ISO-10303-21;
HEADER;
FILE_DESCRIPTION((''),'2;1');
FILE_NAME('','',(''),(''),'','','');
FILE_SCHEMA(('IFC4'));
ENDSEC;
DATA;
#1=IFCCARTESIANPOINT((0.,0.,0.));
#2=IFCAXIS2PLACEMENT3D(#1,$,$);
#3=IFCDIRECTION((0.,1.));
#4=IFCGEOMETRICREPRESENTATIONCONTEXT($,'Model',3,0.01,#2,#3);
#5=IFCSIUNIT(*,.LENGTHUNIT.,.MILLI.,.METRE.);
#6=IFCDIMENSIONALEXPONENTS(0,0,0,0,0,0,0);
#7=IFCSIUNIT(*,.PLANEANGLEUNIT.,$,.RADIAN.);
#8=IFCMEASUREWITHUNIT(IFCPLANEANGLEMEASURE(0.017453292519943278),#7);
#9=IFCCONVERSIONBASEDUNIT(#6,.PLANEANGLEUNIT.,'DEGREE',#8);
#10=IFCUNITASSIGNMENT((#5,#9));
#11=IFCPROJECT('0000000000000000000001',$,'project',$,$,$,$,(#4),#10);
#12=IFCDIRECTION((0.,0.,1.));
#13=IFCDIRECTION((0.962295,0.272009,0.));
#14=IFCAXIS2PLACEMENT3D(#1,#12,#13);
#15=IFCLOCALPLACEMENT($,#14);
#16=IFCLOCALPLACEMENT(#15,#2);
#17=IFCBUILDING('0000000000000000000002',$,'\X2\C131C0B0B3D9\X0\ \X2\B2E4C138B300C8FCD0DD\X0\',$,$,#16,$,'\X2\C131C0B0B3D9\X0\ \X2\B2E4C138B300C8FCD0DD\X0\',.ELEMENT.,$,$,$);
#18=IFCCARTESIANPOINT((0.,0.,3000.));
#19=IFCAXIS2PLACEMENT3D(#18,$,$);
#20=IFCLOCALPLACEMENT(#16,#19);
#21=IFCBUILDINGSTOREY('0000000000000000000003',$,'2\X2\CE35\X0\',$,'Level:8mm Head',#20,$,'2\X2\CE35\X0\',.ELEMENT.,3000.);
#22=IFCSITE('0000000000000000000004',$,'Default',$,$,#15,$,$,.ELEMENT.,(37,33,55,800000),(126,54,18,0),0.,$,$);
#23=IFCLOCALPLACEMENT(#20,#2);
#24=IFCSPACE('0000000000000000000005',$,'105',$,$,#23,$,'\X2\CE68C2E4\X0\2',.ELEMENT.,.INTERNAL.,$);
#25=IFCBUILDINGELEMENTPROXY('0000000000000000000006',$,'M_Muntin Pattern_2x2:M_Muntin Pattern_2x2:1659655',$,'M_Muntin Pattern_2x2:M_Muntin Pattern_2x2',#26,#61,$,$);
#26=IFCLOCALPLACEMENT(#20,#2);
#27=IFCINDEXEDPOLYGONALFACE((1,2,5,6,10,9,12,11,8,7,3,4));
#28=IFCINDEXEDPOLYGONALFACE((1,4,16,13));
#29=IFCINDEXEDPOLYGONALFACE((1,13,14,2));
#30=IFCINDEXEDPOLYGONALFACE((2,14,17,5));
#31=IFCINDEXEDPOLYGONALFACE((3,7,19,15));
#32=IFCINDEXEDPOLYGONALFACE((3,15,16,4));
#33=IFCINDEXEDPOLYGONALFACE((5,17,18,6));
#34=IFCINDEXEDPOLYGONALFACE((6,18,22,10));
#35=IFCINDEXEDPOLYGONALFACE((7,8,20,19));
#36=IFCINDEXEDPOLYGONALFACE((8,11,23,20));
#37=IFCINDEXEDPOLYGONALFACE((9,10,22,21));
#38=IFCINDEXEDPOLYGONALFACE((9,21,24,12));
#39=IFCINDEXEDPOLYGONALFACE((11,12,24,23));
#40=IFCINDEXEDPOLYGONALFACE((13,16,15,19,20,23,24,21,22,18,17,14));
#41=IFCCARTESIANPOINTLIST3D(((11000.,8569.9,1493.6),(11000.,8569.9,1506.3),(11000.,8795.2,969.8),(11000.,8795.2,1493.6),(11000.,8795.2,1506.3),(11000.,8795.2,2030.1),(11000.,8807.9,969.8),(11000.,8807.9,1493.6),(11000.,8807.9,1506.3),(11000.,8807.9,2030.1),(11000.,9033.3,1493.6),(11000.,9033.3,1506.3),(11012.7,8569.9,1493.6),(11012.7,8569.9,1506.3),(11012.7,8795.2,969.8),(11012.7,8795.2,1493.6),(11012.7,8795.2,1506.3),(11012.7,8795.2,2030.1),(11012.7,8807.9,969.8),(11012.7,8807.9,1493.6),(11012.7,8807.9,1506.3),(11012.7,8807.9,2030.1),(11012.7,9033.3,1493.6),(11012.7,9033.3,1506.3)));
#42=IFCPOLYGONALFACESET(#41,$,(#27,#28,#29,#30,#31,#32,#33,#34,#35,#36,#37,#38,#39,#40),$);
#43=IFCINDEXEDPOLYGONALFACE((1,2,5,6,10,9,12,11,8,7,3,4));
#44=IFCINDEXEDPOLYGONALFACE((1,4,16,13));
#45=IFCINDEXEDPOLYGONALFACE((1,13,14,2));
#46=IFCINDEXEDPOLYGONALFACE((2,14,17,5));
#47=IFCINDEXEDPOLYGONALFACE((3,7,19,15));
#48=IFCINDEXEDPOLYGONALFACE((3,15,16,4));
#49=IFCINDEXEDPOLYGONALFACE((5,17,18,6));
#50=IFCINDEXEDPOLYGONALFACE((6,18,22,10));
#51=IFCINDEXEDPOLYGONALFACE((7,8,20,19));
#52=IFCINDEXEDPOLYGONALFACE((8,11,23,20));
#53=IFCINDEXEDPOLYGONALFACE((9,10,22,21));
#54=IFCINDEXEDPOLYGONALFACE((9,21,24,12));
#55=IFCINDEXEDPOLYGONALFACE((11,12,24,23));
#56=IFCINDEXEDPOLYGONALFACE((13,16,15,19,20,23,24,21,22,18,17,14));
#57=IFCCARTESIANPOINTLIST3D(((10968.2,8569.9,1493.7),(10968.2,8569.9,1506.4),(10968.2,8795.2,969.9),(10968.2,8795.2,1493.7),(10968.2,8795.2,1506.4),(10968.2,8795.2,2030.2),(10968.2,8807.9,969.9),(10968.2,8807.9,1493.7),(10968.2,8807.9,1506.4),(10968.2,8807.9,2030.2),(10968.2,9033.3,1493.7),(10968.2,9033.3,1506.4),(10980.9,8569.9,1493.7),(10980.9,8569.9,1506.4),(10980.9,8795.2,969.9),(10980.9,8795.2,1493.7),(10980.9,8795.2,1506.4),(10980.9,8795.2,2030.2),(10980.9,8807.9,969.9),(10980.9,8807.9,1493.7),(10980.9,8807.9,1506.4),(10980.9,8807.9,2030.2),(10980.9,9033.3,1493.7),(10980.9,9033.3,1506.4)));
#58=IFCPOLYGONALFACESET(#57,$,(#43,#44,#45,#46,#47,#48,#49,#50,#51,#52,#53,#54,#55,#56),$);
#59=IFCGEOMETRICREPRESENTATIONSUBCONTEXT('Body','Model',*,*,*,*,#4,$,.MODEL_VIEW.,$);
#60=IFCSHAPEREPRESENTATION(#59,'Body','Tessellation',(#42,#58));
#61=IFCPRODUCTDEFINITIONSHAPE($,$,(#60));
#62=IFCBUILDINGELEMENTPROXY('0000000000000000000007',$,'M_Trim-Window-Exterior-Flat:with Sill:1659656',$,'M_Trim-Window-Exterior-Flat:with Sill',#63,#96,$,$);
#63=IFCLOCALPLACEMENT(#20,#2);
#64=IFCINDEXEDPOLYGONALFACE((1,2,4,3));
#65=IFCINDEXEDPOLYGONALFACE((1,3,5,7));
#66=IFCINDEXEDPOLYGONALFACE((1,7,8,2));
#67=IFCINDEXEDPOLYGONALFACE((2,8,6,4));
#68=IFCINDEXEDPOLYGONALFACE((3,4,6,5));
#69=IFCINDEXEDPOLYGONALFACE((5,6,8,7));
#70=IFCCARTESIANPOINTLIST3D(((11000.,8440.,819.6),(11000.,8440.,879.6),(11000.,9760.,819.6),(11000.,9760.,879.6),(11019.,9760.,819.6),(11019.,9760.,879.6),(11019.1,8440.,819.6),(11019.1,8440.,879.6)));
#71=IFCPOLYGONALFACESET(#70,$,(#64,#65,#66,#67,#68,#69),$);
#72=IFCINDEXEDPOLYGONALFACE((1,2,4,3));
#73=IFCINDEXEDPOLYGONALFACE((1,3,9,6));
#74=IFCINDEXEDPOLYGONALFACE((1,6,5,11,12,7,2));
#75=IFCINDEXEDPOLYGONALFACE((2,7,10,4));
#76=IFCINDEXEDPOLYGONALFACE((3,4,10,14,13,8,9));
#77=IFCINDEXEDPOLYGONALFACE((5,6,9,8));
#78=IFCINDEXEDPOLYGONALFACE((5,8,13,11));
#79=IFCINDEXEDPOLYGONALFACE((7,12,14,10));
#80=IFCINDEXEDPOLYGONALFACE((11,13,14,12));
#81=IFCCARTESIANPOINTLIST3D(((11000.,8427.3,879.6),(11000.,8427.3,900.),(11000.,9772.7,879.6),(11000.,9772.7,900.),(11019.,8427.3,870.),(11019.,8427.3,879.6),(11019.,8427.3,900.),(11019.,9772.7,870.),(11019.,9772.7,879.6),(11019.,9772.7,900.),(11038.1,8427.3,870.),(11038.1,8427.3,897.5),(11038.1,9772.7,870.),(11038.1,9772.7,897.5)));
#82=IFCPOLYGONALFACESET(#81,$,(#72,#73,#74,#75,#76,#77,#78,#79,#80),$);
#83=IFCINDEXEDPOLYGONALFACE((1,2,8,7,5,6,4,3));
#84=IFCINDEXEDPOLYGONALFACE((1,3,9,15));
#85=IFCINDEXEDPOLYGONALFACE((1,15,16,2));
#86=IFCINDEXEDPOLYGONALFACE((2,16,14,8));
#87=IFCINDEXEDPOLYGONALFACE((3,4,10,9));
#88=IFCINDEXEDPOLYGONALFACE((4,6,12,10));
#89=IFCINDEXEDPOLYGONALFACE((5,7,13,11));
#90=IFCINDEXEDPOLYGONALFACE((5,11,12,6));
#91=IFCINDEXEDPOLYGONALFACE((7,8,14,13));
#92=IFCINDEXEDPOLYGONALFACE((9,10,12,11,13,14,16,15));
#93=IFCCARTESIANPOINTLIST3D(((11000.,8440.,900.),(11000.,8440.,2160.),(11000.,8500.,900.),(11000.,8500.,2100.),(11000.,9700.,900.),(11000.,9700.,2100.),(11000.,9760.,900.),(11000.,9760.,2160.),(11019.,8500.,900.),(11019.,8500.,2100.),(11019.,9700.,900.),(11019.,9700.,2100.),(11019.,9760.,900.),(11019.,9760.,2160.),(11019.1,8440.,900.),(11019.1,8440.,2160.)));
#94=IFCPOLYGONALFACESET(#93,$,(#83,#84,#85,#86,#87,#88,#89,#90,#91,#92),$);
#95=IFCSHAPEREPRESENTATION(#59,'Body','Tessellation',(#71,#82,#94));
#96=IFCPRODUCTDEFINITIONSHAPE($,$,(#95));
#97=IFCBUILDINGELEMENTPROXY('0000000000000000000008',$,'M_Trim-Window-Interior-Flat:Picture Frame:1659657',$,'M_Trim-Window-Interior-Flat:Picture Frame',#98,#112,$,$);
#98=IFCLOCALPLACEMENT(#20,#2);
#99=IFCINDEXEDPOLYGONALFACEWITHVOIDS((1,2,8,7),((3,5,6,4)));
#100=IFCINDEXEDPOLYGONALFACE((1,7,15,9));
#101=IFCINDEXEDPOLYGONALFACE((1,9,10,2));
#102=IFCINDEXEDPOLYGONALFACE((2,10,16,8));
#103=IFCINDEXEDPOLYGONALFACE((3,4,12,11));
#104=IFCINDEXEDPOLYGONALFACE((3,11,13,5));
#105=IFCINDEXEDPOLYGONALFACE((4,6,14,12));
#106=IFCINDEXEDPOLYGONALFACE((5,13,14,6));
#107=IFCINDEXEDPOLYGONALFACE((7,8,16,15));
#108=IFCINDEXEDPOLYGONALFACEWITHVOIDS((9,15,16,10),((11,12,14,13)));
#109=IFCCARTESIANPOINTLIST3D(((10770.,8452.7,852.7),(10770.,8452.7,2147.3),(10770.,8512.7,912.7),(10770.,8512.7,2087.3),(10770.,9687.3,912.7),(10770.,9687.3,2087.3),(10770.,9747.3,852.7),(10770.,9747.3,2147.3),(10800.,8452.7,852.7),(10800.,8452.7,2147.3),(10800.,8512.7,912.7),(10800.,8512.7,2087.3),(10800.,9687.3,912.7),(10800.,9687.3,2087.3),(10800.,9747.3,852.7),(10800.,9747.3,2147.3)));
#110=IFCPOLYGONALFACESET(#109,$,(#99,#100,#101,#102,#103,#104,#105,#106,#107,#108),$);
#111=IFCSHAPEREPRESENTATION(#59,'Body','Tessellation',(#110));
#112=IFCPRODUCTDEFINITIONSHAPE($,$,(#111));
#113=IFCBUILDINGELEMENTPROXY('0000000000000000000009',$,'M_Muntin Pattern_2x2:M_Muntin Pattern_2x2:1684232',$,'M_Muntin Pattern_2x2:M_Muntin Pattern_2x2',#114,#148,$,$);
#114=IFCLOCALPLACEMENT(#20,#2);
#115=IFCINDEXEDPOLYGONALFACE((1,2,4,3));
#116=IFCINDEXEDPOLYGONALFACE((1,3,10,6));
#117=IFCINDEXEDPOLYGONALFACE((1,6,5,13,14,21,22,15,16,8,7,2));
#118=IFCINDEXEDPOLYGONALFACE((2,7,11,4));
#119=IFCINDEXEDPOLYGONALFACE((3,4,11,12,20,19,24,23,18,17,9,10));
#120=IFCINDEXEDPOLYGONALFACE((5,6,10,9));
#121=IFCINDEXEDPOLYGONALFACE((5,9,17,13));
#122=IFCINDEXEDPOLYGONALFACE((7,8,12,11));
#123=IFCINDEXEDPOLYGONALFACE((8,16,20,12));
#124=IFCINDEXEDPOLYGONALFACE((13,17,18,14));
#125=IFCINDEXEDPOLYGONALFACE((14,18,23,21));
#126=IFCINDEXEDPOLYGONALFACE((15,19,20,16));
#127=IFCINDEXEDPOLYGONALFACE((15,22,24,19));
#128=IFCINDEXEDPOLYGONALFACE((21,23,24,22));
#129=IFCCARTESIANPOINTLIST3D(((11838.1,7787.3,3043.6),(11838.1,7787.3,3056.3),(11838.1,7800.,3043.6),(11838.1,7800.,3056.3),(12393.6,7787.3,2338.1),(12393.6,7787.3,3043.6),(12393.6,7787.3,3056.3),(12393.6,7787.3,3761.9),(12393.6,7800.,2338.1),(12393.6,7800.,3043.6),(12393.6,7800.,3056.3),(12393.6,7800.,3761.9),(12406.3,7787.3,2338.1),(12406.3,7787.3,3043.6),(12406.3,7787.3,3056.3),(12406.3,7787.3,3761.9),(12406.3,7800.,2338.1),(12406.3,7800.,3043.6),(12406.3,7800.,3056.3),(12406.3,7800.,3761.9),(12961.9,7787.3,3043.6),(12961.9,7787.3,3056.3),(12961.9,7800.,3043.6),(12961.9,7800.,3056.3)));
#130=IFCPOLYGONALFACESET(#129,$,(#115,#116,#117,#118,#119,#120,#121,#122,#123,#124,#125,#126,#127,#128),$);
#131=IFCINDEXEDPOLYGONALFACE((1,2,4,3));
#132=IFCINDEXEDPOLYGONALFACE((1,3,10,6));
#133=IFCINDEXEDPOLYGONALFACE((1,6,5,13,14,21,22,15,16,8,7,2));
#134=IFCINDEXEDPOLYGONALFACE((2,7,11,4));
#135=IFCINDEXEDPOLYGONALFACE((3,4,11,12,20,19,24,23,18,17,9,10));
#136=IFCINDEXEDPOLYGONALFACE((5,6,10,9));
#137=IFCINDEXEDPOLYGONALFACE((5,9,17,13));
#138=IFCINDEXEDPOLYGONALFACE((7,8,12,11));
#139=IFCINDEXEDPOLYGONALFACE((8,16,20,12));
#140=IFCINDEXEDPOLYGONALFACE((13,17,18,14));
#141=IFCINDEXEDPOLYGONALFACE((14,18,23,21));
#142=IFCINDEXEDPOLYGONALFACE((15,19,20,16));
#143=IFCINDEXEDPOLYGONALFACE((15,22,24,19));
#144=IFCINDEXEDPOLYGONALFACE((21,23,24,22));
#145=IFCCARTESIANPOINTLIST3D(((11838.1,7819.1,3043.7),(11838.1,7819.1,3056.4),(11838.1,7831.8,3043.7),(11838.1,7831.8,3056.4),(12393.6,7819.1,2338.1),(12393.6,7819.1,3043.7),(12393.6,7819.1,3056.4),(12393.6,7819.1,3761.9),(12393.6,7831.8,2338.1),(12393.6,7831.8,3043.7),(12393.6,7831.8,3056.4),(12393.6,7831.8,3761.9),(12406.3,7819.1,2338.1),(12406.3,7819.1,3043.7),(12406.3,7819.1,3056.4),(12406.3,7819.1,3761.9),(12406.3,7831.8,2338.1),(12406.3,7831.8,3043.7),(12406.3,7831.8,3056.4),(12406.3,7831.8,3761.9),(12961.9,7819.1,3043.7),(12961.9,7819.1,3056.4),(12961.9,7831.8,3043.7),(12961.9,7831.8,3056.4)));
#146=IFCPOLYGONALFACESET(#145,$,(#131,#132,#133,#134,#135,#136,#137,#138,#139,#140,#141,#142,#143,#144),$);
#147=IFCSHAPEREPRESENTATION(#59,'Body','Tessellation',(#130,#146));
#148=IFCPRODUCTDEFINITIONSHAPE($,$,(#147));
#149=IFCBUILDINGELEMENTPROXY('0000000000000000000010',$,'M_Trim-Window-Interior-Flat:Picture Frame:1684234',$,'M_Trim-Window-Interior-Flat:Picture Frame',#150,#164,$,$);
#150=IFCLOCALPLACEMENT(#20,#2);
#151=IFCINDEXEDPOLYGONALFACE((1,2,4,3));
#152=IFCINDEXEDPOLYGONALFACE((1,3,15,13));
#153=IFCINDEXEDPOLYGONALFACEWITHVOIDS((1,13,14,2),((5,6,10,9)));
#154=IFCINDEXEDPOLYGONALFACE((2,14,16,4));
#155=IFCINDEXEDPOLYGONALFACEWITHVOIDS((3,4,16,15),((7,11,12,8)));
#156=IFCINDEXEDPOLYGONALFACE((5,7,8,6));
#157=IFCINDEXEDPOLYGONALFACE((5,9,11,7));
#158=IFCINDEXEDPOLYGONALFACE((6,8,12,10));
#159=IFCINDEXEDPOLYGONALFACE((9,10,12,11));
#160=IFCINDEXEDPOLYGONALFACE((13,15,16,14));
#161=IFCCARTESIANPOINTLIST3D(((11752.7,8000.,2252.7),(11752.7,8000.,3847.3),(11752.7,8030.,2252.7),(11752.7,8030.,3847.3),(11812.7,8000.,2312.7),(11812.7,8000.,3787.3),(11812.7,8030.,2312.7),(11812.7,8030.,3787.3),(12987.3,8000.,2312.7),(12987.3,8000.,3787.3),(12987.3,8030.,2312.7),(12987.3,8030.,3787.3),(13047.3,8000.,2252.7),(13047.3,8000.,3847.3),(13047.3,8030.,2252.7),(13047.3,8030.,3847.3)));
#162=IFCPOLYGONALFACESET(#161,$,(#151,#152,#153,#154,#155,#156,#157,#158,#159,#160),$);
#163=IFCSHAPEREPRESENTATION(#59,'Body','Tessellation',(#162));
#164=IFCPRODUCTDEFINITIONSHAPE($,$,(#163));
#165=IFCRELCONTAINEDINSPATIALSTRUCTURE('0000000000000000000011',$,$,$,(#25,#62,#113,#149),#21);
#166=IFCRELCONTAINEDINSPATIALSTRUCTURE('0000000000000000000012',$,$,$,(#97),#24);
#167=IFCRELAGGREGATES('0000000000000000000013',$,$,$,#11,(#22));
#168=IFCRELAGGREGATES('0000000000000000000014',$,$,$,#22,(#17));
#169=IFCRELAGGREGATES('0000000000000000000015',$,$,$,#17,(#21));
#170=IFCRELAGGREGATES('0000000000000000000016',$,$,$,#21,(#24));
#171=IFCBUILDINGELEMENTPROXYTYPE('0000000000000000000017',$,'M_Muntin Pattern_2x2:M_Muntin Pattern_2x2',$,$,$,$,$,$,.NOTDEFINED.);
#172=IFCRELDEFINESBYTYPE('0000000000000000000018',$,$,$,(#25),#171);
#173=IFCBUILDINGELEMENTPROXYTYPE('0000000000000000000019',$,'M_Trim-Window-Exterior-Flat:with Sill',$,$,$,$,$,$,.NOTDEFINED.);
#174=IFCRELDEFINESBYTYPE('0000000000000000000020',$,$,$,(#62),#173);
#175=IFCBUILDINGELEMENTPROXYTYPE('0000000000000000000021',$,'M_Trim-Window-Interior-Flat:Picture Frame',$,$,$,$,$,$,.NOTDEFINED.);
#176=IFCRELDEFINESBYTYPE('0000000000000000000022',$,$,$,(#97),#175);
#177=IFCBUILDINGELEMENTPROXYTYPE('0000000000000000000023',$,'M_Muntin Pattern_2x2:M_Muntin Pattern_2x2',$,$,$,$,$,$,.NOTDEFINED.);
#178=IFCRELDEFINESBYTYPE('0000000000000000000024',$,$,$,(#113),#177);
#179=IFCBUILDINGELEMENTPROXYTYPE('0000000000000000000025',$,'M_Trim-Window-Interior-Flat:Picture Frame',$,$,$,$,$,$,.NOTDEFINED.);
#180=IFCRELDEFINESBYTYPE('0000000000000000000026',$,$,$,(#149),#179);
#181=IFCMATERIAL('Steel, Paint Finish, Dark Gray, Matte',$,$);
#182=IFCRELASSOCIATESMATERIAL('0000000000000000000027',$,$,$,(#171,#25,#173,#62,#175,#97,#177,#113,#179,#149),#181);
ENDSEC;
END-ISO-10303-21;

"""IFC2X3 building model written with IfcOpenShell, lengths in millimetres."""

from ifc_helpers import new_model, entity, si_unit, converted_unit, direction, frame, frame_2d, origin, place, context, subcontext, project, spatial, polyline, rectangle, outline, extrude, source, transform, mapped, material, type_object, type_shapes, element, save


model = new_model("IFC2X3")

# Units and contexts
model_context = context("Model", 3, precision=0.01, world=origin(), true_north=direction((0.0, 1.0)))
body_context = subcontext(model_context, "Body", "Model", "MODEL_VIEW")
ifc_project = project(units=[si_unit("LENGTHUNIT", "METRE", prefix="MILLI"), converted_unit("PLANEANGLEUNIT", "DEGREE", entity("IfcPlaneAngleMeasure", 0.017453292519943278), si_unit("PLANEANGLEUNIT", "RADIAN"), dimensions=[0, 0, 0, 0, 0, 0, 0])], contexts=[model_context])

# Site, building, storey
site_placement = place(None, frame((0.0, 0.0, 0.0), z_axis=(0.0, 0.0, 1.0), x_axis=(0.962295, 0.272009, 0.0)))
site = spatial("IfcSite", under=ifc_project, at=site_placement, Name="Default", CompositionType="ELEMENT", RefLatitude=(37, 33, 55, 800000), RefLongitude=(126, 54, 18, 0), RefElevation=0.0)
building_placement = place(site_placement, origin())
building = spatial("IfcBuilding", under=site, at=building_placement, Name="성산동 다세대주택", LongName="성산동 다세대주택", CompositionType="ELEMENT")
storey_placement = place(building_placement, frame((0.0, 0.0, 3000.0)))
storey = spatial("IfcBuildingStorey", under=building, at=storey_placement, Name="2층", ObjectType="Level:8mm Head", LongName="2층", CompositionType="ELEMENT", Elevation=3000.0)

# Shared definitions
ifc_material_1 = material(Name="Steel, Paint Finish, Dark Gray, Matte")

# Building element proxies
building_element_proxy_type_1 = type_object("IfcBuildingElementProxyType", Name="M_Muntin Pattern_2x2:M_Muntin Pattern_2x2", PredefinedType="NOTDEFINED", material=ifc_material_1)
shared_shape_1 = source(origin(), body_context, "Body", "SweptSolid", [
    extrude(outline(polyline([(6.4, -6.4), (530.1, -6.4), (530.1, 6.3), (6.4, 6.3), (6.4, 231.7), (-6.3, 231.7), (-6.3, 6.3), (-530.2, 6.3), (-530.2, -6.4), (-6.3, -6.4), (-6.3, -231.7), (6.4, -231.7), (6.4, -6.4)])), frame((0.0, -22.2, 530.1), z_axis=(0.0, 1.0, 0.0), x_axis=(0.0, 0.0, 1.0)), (0.0, 0.0, 1.0), 12.7),
    extrude(outline(polyline([(6.4, -6.4), (530.2, -6.4), (530.2, 6.3), (6.4, 6.3), (6.4, 231.7), (-6.3, 231.7), (-6.3, 6.3), (-530.2, 6.3), (-530.2, -6.4), (-6.3, -6.4), (-6.3, -231.7), (6.4, -231.7), (6.4, -6.4)])), frame((0.0, 9.5, 530.2), z_axis=(0.0, 1.0, 0.0), x_axis=(0.0, 0.0, 1.0)), (0.0, 0.0, 1.0), 12.7),
])
type_shapes(building_element_proxy_type_1, [shared_shape_1])
proxy_1_placement = place(storey_placement, frame((10990.5, 8801.6, 969.9), z_axis=(0.0, 0.0, 1.0), x_axis=(0.0, 1.0, 0.0)))
element("IfcBuildingElementProxy", 1, at=proxy_1_placement, inside=storey, type_object=building_element_proxy_type_1, material=ifc_material_1, Name="M_Muntin Pattern_2x2:M_Muntin Pattern_2x2:1659655", ObjectType="M_Muntin Pattern_2x2:M_Muntin Pattern_2x2", context=body_context, shape_type="MappedRepresentation", body=[
    mapped(shared_shape_1, transform((0.0, 0.0, 0.0), scale=1.0)),
])
building_element_proxy_type_2 = type_object("IfcBuildingElementProxyType", Name="M_Trim-Window-Exterior-Flat:with Sill", PredefinedType="NOTDEFINED", material=ifc_material_1)
shared_shape_2 = source(origin(), body_context, "Body", "SweptSolid", [
    extrude(rectangle(XDim=1320.0, YDim=60.0, at=frame_2d((0.0, 0.0), x_axis=(1.0, 0.0))), frame((0.0, -1250.4, 0.0), z_axis=(0.0, 0.0, 1.0), x_axis=(-1.0, 0.0, 0.0)), (0.0, 0.0, 1.0), 19.0),
    extrude(outline(polyline([(-19.0, -15.2), (0.0, -15.2), (0.0, -5.7), (19.0, -5.7), (19.0, 14.8), (0.0, 14.8), (-19.0, 12.3), (-19.0, -15.2)])), frame((-672.7, -1214.8, 19.0), z_axis=(1.0, 0.0, 0.0), x_axis=(0.0, 0.0, -1.0)), (0.0, 0.0, 1.0), 1345.4),
    extrude(outline(polyline([(-645.0, -660.0), (615.0, -660.0), (615.0, -600.0), (-585.0, -600.0), (-585.0, 600.0), (615.0, 600.0), (615.0, 660.0), (-645.0, 660.0), (-645.0, -660.0)])), frame((0.0, -585.0, 0.0), z_axis=(0.0, 0.0, 1.0), x_axis=(0.0, -1.0, 0.0)), (0.0, 0.0, 1.0), 19.0),
])
type_shapes(building_element_proxy_type_2, [shared_shape_2])
proxy_2_placement = place(storey_placement, frame((11000.0, 9100.0, 2100.0), z_axis=(1.0, 0.0, 0.0), x_axis=(0.0, 1.0, 0.0)))
element("IfcBuildingElementProxy", 2, at=proxy_2_placement, inside=storey, type_object=building_element_proxy_type_2, material=ifc_material_1, Name="M_Trim-Window-Exterior-Flat:with Sill:1659656", ObjectType="M_Trim-Window-Exterior-Flat:with Sill", context=body_context, shape_type="MappedRepresentation", body=[
    mapped(shared_shape_2, transform((0.0, 0.0, 0.0), scale=1.0)),
])

# Shared definitions
space_1_placement = place(storey_placement, origin())
space_1 = spatial("IfcSpace", under=storey, at=space_1_placement, Name="105", LongName="침실2", CompositionType="ELEMENT", InteriorOrExteriorSpace="INTERNAL")

# Building element proxies
building_element_proxy_type_3 = type_object("IfcBuildingElementProxyType", Name="M_Trim-Window-Interior-Flat:Picture Frame", PredefinedType="NOTDEFINED", material=ifc_material_1)
shared_shape_3 = source(origin(), body_context, "Body", "SweptSolid", [
    extrude(outline(polyline([(-647.3, -647.3), (647.3, -647.3), (647.3, 647.3), (-647.3, 647.3), (-647.3, -647.3)]), holes=[polyline([(-587.3, -587.3), (-587.3, 587.3), (587.3, 587.3), (587.3, -587.3), (-587.3, -587.3)])]), frame((0.0, -600.0, 0.0), z_axis=(0.0, 0.0, 1.0), x_axis=(-1.0, 0.0, 0.0)), (0.0, 0.0, 1.0), 30.0),
])
type_shapes(building_element_proxy_type_3, [shared_shape_3])
proxy_3_placement = place(space_1_placement, frame((10800.0, 9100.0, 2100.0), z_axis=(-1.0, 0.0, 0.0), x_axis=(0.0, -1.0, 0.0)))
element("IfcBuildingElementProxy", 3, at=proxy_3_placement, inside=space_1, type_object=building_element_proxy_type_3, material=ifc_material_1, Name="M_Trim-Window-Interior-Flat:Picture Frame:1659657", ObjectType="M_Trim-Window-Interior-Flat:Picture Frame", context=body_context, shape_type="MappedRepresentation", body=[
    mapped(shared_shape_3, transform((0.0, 0.0, 0.0), scale=1.0)),
])
building_element_proxy_type_4 = type_object("IfcBuildingElementProxyType", Name="M_Muntin Pattern_2x2:M_Muntin Pattern_2x2", PredefinedType="NOTDEFINED", material=ifc_material_1)
shared_shape_4 = source(origin(), body_context, "Body", "SweptSolid", [
    extrude(outline(polyline([(6.4, -6.4), (711.9, -6.4), (711.9, 6.3), (6.4, 6.3), (6.4, 561.9), (-6.3, 561.9), (-6.3, 6.3), (-711.9, 6.3), (-711.9, -6.4), (-6.3, -6.4), (-6.3, -561.9), (6.4, -561.9), (6.4, -6.4)])), frame((0.0, -22.2, 711.9), z_axis=(0.0, 1.0, 0.0), x_axis=(0.0, 0.0, 1.0)), (0.0, 0.0, 1.0), 12.7),
    extrude(outline(polyline([(6.4, -6.4), (711.9, -6.4), (711.9, 6.3), (6.4, 6.3), (6.4, 561.9), (-6.3, 561.9), (-6.3, 6.3), (-711.9, 6.3), (-711.9, -6.4), (-6.3, -6.4), (-6.3, -561.9), (6.4, -561.9), (6.4, -6.4)])), frame((0.0, 9.5, 711.9), z_axis=(0.0, 1.0, 0.0), x_axis=(0.0, 0.0, 1.0)), (0.0, 0.0, 1.0), 12.7),
])
type_shapes(building_element_proxy_type_4, [shared_shape_4])
proxy_4_placement = place(storey_placement, frame((12400.0, 7809.5, 2338.1)))
element("IfcBuildingElementProxy", 4, at=proxy_4_placement, inside=storey, type_object=building_element_proxy_type_4, material=ifc_material_1, Name="M_Muntin Pattern_2x2:M_Muntin Pattern_2x2:1684232", ObjectType="M_Muntin Pattern_2x2:M_Muntin Pattern_2x2", context=body_context, shape_type="MappedRepresentation", body=[
    mapped(shared_shape_4, transform((0.0, 0.0, 0.0), scale=1.0)),
])
building_element_proxy_type_5 = type_object("IfcBuildingElementProxyType", Name="M_Trim-Window-Interior-Flat:Picture Frame", PredefinedType="NOTDEFINED", material=ifc_material_1)
shared_shape_5 = source(origin(), body_context, "Body", "SweptSolid", [
    extrude(outline(polyline([(-647.3, -797.3), (647.3, -797.3), (647.3, 797.3), (-647.3, 797.3), (-647.3, -797.3)]), holes=[polyline([(-587.3, -737.3), (-587.3, 737.3), (587.3, 737.3), (587.3, -737.3), (-587.3, -737.3)])]), frame((0.0, -750.0, 0.0), z_axis=(0.0, 0.0, 1.0), x_axis=(-1.0, 0.0, 0.0)), (0.0, 0.0, 1.0), 30.0),
])
type_shapes(building_element_proxy_type_5, [shared_shape_5])
proxy_5_placement = place(storey_placement, frame((12400.0, 8000.0, 3800.0), z_axis=(0.0, 1.0, 0.0), x_axis=(-1.0, 0.0, 0.0)))
element("IfcBuildingElementProxy", 5, at=proxy_5_placement, inside=storey, type_object=building_element_proxy_type_5, material=ifc_material_1, Name="M_Trim-Window-Interior-Flat:Picture Frame:1684234", ObjectType="M_Trim-Window-Interior-Flat:Picture Frame", context=body_context, shape_type="MappedRepresentation", body=[
    mapped(shared_shape_5, transform((0.0, 0.0, 0.0), scale=1.0)),
])

save(model, "model.ifc")
